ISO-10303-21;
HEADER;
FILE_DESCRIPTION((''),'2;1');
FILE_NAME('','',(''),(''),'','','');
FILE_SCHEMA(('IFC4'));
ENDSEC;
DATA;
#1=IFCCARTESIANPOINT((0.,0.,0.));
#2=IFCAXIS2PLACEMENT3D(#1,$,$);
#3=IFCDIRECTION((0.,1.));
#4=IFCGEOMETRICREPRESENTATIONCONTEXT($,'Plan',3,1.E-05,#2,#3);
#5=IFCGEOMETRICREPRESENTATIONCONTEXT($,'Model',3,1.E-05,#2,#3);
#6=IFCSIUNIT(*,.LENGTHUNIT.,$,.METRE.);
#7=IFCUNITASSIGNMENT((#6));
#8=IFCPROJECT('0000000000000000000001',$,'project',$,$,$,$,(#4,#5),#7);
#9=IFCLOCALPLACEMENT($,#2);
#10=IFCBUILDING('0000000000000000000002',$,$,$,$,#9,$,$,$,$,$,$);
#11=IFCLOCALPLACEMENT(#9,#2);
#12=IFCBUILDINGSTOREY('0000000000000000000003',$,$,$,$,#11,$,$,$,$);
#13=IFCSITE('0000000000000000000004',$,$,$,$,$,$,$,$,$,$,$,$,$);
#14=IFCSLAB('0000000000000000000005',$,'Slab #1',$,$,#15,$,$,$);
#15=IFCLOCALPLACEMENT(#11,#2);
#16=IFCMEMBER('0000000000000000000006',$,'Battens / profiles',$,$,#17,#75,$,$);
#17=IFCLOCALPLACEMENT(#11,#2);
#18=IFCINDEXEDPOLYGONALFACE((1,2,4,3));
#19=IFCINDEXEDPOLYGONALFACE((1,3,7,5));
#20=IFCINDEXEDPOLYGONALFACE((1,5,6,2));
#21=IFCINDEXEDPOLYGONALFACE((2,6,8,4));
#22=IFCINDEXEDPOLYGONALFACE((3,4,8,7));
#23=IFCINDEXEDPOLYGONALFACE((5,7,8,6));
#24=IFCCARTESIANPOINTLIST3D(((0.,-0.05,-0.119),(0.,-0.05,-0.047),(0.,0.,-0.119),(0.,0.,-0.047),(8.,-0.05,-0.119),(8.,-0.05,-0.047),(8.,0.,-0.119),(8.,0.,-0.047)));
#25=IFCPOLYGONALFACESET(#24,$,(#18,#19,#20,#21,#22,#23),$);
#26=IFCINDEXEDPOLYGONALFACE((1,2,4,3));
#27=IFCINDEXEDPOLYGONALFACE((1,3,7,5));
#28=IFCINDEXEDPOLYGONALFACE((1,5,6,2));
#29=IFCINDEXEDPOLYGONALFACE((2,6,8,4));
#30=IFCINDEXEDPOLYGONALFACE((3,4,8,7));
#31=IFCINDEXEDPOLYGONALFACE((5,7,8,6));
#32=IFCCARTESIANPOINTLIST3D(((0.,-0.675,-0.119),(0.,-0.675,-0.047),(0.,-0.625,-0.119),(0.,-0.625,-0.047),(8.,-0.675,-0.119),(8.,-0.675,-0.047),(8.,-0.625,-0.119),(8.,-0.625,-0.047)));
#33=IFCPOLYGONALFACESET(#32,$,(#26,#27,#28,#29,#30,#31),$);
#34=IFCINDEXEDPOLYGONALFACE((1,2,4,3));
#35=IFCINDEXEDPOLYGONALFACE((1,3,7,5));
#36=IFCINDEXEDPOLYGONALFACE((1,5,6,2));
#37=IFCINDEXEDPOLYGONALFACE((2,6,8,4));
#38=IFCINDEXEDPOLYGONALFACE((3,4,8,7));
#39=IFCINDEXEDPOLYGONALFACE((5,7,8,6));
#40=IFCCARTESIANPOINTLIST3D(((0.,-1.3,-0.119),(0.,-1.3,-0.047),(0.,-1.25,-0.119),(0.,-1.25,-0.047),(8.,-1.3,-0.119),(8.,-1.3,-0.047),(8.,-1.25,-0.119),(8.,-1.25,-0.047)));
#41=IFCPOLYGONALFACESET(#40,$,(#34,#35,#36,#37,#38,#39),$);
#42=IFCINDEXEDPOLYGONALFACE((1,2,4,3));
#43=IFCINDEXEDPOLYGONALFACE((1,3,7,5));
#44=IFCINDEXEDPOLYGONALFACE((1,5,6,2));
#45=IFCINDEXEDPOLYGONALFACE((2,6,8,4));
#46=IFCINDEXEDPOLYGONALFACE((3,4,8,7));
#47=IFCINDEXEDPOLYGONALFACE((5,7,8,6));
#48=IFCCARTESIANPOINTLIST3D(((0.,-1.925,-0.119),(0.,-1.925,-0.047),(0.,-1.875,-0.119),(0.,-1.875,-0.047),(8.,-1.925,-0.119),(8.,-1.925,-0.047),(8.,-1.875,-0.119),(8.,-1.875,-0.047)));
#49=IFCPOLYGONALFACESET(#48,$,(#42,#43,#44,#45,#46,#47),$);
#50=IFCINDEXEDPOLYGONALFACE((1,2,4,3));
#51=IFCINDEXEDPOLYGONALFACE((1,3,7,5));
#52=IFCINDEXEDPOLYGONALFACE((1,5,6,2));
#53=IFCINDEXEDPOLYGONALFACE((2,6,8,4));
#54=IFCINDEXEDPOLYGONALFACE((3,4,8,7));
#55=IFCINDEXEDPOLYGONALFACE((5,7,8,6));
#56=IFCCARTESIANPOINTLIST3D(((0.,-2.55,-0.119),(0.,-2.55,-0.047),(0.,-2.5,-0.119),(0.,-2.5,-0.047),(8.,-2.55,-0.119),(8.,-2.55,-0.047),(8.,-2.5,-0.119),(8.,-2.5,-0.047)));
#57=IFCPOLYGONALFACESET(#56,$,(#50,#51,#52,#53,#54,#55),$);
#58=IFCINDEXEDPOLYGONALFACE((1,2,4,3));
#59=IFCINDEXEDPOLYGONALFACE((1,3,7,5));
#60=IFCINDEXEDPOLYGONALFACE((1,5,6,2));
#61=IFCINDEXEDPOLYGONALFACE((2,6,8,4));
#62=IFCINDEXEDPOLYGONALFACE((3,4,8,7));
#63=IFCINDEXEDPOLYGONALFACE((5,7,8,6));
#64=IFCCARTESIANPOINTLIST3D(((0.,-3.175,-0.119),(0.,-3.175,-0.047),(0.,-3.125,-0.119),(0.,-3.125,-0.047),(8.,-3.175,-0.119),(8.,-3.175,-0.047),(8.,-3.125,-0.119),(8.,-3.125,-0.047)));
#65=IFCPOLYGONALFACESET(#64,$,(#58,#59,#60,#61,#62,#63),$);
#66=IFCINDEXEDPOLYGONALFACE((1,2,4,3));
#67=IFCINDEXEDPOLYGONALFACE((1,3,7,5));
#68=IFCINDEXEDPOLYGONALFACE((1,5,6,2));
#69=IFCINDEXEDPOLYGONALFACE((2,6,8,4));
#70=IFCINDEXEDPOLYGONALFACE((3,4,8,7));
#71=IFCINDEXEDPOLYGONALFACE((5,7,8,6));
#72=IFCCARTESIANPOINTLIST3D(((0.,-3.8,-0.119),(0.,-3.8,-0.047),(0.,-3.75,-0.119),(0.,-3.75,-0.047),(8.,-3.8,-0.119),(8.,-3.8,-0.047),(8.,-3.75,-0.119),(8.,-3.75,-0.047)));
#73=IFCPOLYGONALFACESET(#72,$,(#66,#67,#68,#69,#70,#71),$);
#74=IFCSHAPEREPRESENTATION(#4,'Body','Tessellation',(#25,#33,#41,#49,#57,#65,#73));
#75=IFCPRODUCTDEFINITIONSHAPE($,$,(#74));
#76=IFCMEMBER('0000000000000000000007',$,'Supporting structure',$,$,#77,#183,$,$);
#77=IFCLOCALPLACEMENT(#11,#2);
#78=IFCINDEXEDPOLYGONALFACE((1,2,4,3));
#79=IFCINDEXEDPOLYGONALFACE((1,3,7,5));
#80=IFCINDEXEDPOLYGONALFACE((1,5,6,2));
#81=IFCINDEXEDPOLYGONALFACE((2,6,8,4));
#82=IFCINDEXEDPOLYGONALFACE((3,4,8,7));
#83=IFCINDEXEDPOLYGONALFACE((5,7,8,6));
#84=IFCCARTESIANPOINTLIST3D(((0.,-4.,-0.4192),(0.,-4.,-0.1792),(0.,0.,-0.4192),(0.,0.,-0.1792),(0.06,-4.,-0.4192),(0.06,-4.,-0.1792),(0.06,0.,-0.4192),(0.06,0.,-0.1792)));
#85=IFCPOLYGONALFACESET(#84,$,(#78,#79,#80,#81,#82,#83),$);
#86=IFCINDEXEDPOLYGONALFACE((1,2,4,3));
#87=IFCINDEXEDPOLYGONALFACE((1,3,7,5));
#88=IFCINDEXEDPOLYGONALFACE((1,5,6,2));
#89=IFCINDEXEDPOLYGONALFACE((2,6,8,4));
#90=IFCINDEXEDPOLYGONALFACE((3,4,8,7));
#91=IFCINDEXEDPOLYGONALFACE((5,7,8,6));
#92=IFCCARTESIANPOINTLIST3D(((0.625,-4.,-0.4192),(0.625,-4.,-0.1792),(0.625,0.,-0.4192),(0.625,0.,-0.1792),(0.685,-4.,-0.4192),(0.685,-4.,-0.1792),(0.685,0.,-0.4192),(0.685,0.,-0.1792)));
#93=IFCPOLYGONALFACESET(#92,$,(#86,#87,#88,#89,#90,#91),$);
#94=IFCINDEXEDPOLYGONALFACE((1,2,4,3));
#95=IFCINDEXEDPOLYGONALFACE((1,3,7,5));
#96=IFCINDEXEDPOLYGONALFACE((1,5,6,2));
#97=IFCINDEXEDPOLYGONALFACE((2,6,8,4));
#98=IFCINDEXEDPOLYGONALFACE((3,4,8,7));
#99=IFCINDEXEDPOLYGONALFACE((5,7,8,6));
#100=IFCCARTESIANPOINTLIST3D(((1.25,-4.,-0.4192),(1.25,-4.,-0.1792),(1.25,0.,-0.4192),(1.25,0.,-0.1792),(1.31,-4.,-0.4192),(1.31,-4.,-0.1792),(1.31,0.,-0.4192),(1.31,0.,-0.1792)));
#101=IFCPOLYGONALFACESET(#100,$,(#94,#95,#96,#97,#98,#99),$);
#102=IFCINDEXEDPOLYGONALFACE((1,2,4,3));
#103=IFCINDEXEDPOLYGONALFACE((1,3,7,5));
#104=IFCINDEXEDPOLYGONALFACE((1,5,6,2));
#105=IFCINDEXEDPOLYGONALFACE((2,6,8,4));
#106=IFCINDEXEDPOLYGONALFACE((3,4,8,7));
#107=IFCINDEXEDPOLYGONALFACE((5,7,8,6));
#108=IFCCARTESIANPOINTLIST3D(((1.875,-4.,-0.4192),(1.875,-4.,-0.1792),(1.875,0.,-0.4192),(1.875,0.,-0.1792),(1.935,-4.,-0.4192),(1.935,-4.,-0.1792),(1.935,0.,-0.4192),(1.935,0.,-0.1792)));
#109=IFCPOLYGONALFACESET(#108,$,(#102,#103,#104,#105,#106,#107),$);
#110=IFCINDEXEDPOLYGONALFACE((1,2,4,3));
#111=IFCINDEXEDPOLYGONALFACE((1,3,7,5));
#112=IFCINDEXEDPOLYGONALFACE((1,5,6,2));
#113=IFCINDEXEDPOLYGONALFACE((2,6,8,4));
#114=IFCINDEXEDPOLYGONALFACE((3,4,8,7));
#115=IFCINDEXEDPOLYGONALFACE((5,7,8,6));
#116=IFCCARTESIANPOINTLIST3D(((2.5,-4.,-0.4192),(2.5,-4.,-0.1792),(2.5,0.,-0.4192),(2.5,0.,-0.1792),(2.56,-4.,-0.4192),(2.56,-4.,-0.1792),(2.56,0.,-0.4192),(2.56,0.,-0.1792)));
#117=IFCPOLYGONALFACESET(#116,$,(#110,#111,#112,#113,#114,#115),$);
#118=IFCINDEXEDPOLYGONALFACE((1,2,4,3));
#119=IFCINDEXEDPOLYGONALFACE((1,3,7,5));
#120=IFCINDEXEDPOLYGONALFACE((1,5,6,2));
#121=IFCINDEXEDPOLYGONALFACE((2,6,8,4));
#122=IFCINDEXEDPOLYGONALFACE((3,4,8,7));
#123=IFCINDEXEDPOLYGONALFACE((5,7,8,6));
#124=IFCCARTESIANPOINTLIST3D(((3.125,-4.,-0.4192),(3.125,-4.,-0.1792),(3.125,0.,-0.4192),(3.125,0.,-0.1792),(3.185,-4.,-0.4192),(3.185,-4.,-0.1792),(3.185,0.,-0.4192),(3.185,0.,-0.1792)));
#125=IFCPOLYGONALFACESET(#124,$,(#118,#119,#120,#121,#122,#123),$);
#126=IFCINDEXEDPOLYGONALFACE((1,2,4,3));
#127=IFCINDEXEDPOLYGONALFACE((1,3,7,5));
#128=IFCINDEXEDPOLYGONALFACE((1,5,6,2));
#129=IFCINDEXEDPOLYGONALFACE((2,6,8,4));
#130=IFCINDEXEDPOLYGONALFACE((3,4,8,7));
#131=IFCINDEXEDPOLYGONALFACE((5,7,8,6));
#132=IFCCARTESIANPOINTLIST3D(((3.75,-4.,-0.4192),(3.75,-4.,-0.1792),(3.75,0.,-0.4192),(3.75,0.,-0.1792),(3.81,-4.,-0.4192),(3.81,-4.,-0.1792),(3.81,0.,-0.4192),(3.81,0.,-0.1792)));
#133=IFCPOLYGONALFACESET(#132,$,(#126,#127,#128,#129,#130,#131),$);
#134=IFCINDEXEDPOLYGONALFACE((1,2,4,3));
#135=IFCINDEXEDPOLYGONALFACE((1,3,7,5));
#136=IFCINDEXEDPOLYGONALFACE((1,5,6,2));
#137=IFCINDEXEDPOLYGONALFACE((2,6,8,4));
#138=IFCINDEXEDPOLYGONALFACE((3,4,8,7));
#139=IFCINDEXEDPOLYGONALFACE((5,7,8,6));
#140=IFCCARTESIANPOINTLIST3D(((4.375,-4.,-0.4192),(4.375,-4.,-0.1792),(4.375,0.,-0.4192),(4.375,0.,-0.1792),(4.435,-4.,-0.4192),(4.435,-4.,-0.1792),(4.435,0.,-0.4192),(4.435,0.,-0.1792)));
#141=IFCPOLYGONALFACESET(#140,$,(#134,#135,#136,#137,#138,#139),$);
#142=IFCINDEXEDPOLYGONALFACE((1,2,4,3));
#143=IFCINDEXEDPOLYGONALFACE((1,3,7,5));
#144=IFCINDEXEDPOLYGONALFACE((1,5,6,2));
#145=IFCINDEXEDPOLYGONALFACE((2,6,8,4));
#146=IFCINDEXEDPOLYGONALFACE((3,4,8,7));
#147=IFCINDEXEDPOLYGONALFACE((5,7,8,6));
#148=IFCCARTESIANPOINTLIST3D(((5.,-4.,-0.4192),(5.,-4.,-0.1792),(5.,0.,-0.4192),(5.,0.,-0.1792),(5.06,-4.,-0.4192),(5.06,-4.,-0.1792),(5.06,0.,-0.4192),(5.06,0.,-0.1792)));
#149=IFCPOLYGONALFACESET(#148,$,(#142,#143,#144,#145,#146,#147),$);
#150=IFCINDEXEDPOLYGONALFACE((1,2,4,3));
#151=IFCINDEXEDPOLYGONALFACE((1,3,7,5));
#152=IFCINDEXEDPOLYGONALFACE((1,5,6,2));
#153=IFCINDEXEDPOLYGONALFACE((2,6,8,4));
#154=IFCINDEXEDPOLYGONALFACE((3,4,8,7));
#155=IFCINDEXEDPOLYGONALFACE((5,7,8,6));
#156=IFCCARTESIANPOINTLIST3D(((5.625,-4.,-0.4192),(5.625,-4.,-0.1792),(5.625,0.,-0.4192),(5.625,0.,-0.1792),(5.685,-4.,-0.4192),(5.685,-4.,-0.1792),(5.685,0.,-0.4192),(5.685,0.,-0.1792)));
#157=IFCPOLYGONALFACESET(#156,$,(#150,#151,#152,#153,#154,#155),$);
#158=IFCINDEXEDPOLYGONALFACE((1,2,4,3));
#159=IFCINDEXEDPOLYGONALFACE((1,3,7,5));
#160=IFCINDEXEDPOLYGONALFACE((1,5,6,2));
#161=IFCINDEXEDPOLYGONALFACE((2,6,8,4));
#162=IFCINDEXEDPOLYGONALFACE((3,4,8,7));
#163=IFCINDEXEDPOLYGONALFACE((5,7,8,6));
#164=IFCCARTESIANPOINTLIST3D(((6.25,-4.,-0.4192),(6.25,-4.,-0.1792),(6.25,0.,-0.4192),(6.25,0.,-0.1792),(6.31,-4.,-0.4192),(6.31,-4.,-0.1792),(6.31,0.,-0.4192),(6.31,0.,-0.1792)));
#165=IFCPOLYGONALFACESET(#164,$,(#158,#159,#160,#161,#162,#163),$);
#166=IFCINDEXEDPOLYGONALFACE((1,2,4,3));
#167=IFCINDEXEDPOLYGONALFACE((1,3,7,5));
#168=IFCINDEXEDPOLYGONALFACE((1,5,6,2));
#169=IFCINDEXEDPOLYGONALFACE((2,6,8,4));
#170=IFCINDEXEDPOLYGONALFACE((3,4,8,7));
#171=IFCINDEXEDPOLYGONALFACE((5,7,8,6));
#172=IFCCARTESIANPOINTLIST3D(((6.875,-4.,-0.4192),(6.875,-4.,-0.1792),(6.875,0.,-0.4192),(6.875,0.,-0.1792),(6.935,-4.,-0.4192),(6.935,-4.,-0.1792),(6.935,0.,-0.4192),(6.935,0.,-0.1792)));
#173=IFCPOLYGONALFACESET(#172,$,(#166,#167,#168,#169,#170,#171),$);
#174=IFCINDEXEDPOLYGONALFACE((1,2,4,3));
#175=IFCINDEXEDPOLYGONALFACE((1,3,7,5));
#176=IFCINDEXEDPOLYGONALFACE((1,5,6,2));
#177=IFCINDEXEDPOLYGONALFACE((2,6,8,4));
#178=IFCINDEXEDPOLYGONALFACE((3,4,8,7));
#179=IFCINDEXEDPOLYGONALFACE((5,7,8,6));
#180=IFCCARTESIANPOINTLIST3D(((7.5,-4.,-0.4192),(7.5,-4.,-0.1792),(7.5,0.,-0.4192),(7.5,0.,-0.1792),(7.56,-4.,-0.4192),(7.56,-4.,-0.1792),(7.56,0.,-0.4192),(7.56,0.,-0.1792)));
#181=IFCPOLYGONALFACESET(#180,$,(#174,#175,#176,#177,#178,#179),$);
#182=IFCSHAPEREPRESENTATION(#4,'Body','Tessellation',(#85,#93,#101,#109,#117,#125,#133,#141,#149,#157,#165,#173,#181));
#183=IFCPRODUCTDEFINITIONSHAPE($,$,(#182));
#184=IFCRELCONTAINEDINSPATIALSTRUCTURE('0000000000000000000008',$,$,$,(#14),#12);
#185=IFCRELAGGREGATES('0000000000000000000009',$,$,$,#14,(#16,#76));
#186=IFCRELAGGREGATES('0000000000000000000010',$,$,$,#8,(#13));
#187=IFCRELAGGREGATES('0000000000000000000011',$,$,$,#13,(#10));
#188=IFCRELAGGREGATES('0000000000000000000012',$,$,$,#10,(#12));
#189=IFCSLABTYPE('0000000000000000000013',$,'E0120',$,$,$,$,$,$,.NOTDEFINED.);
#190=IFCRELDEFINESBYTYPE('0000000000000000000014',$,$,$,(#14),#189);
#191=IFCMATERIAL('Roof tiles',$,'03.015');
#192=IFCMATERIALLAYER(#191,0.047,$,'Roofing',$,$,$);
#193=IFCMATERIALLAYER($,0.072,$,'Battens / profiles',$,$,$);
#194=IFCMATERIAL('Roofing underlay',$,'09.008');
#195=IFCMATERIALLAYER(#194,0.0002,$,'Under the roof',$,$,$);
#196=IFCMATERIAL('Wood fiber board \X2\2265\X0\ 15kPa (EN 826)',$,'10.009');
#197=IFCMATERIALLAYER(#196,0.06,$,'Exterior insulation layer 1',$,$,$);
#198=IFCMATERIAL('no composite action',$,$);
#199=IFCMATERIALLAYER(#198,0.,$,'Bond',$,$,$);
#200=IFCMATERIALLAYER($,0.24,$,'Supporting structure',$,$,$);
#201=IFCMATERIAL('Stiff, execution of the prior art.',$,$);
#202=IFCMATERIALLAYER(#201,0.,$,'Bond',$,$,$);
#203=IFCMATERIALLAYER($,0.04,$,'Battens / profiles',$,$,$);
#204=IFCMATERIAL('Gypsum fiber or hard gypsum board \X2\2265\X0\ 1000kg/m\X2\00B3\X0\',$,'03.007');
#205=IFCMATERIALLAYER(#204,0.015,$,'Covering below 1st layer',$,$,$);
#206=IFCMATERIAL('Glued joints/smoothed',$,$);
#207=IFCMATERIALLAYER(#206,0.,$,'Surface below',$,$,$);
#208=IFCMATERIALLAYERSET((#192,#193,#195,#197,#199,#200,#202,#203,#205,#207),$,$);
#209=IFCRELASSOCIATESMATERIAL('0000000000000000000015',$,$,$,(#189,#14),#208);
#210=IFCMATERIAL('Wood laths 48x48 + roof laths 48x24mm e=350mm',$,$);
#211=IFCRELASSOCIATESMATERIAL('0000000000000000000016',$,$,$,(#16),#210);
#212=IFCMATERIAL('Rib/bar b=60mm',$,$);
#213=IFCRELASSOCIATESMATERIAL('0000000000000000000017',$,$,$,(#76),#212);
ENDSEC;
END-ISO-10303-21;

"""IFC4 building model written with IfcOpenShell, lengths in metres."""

from ifc_helpers import new_model, si_unit, direction, frame, frame_2d, origin, place, context, project, spatial, rectangle, extrude, material, layer, layer_set, type_object, element, aggregate, save


model = new_model("IFC4")

# Units and contexts
plan_context = context("Plan", 3, precision=1e-05, world=origin(), true_north=direction((0.0, 1.0)))
model_context = context("Model", 3, precision=1e-05, world=origin(), true_north=direction((0.0, 1.0)))
ifc_project = project(units=[si_unit("LENGTHUNIT", "METRE")], contexts=[plan_context, model_context])

# Site, building, storey
site = spatial("IfcSite", under=ifc_project)
building_placement = place(None, origin())
building = spatial("IfcBuilding", under=site, at=building_placement)
storey_placement = place(building_placement, origin())
storey = spatial("IfcBuildingStorey", under=building, at=storey_placement)

# Slab, members
ifc_material_1 = material(Name="Roof tiles", Category="03.015")
ifc_layer_1 = layer(ifc_material_1, 0.047, Name="Roofing")
ifc_layer_2 = layer(None, 0.072, Name="Battens / profiles")
ifc_material_2 = material(Name="Roofing underlay", Category="09.008")
ifc_layer_3 = layer(ifc_material_2, 0.0002, Name="Under the roof")
ifc_material_3 = material(Name="Wood fiber board ≥ 15kPa (EN 826)", Category="10.009")
ifc_layer_4 = layer(ifc_material_3, 0.06, Name="Exterior insulation layer 1")
ifc_material_4 = material(Name="no composite action")
ifc_layer_5 = layer(ifc_material_4, 0.0, Name="Bond")
ifc_layer_6 = layer(None, 0.24, Name="Supporting structure")
ifc_material_5 = material(Name="Stiff, execution of the prior art.")
ifc_layer_7 = layer(ifc_material_5, 0.0, Name="Bond")
ifc_layer_8 = layer(None, 0.04, Name="Battens / profiles")
ifc_material_6 = material(Name="Gypsum fiber or hard gypsum board ≥ 1000kg/m³", Category="03.007")
ifc_layer_9 = layer(ifc_material_6, 0.015, Name="Covering below 1st layer")
ifc_material_7 = material(Name="Glued joints/smoothed")
ifc_layer_10 = layer(ifc_material_7, 0.0, Name="Surface below")
ifc_layer_set = layer_set([ifc_layer_1, ifc_layer_2, ifc_layer_3, ifc_layer_4, ifc_layer_5, ifc_layer_6, ifc_layer_7, ifc_layer_8, ifc_layer_9, ifc_layer_10])
slab_type = type_object("IfcSlabType", Name="E0120", PredefinedType="NOTDEFINED", material=ifc_layer_set)
slab_placement = place(None, frame((0.0, 0.0, 0.0), z_axis=(0.0, 0.0, -1.0), x_axis=(1.0, 0.0, 0.0)))
slab = element("IfcSlab", 1, at=slab_placement, inside=storey, type_object=slab_type, material=ifc_layer_set, Name="Slab #1")
ifc_material_8 = material(Name="Wood laths 48x48 + roof laths 48x24mm e=350mm")
member_1_placement = place(slab_placement, origin())
member_1 = element("IfcMember", 2, at=member_1_placement, material=ifc_material_8, Name="Battens / profiles", context=plan_context, shape_type="SweptSolid", body=[
    extrude(rectangle(XDim=0.05, YDim=0.072, at=frame_2d((0.025, 0.036), x_axis=(1.0, 0.0))), frame((0.0, 0.0, 0.047), z_axis=(1.0, 0.0, 0.0), x_axis=(0.0, 1.0, 0.0)), (0.0, 0.0, 1.0), 8.0),
    extrude(rectangle(XDim=0.05, YDim=0.072, at=frame_2d((0.025, 0.036), x_axis=(1.0, 0.0))), frame((0.0, 0.625, 0.047), z_axis=(1.0, 0.0, 0.0), x_axis=(0.0, 1.0, 0.0)), (0.0, 0.0, 1.0), 8.0),
    extrude(rectangle(XDim=0.05, YDim=0.072, at=frame_2d((0.025, 0.036), x_axis=(1.0, 0.0))), frame((0.0, 1.25, 0.047), z_axis=(1.0, 0.0, 0.0), x_axis=(0.0, 1.0, 0.0)), (0.0, 0.0, 1.0), 8.0),
    extrude(rectangle(XDim=0.05, YDim=0.072, at=frame_2d((0.025, 0.036), x_axis=(1.0, 0.0))), frame((0.0, 1.875, 0.047), z_axis=(1.0, 0.0, 0.0), x_axis=(0.0, 1.0, 0.0)), (0.0, 0.0, 1.0), 8.0),
    extrude(rectangle(XDim=0.05, YDim=0.072, at=frame_2d((0.025, 0.036), x_axis=(1.0, 0.0))), frame((0.0, 2.5, 0.047), z_axis=(1.0, 0.0, 0.0), x_axis=(0.0, 1.0, 0.0)), (0.0, 0.0, 1.0), 8.0),
    extrude(rectangle(XDim=0.05, YDim=0.072, at=frame_2d((0.025, 0.036), x_axis=(1.0, 0.0))), frame((0.0, 3.125, 0.047), z_axis=(1.0, 0.0, 0.0), x_axis=(0.0, 1.0, 0.0)), (0.0, 0.0, 1.0), 8.0),
    extrude(rectangle(XDim=0.05, YDim=0.072, at=frame_2d((0.025, 0.036), x_axis=(1.0, 0.0))), frame((0.0, 3.75, 0.047), z_axis=(1.0, 0.0, 0.0), x_axis=(0.0, 1.0, 0.0)), (0.0, 0.0, 1.0), 8.0),
])
ifc_material_9 = material(Name="Rib/bar b=60mm")
member_2_placement = place(slab_placement, origin())
member_2 = element("IfcMember", 3, at=member_2_placement, material=ifc_material_9, Name="Supporting structure", context=plan_context, shape_type="SweptSolid", body=[
    extrude(rectangle(XDim=0.06, YDim=0.24, at=frame_2d((0.03, 0.12), x_axis=(1.0, 0.0))), frame((0.0, 4.0, 0.1792), z_axis=(0.0, -1.0, 0.0), x_axis=(1.0, 0.0, 0.0)), (0.0, 0.0, 1.0), 4.0),
    extrude(rectangle(XDim=0.06, YDim=0.24, at=frame_2d((0.03, 0.12), x_axis=(1.0, 0.0))), frame((0.625, 4.0, 0.1792), z_axis=(0.0, -1.0, 0.0), x_axis=(1.0, 0.0, 0.0)), (0.0, 0.0, 1.0), 4.0),
    extrude(rectangle(XDim=0.06, YDim=0.24, at=frame_2d((0.03, 0.12), x_axis=(1.0, 0.0))), frame((1.25, 4.0, 0.1792), z_axis=(0.0, -1.0, 0.0), x_axis=(1.0, 0.0, 0.0)), (0.0, 0.0, 1.0), 4.0),
    extrude(rectangle(XDim=0.06, YDim=0.24, at=frame_2d((0.03, 0.12), x_axis=(1.0, 0.0))), frame((1.875, 4.0, 0.1792), z_axis=(0.0, -1.0, 0.0), x_axis=(1.0, 0.0, 0.0)), (0.0, 0.0, 1.0), 4.0),
    extrude(rectangle(XDim=0.06, YDim=0.24, at=frame_2d((0.03, 0.12), x_axis=(1.0, 0.0))), frame((2.5, 4.0, 0.1792), z_axis=(0.0, -1.0, 0.0), x_axis=(1.0, 0.0, 0.0)), (0.0, 0.0, 1.0), 4.0),
    extrude(rectangle(XDim=0.06, YDim=0.24, at=frame_2d((0.03, 0.12), x_axis=(1.0, 0.0))), frame((3.125, 4.0, 0.1792), z_axis=(0.0, -1.0, 0.0), x_axis=(1.0, 0.0, 0.0)), (0.0, 0.0, 1.0), 4.0),
    extrude(rectangle(XDim=0.06, YDim=0.24, at=frame_2d((0.03, 0.12), x_axis=(1.0, 0.0))), frame((3.75, 4.0, 0.1792), z_axis=(0.0, -1.0, 0.0), x_axis=(1.0, 0.0, 0.0)), (0.0, 0.0, 1.0), 4.0),
    extrude(rectangle(XDim=0.06, YDim=0.24, at=frame_2d((0.03, 0.12), x_axis=(1.0, 0.0))), frame((4.375, 4.0, 0.1792), z_axis=(0.0, -1.0, 0.0), x_axis=(1.0, 0.0, 0.0)), (0.0, 0.0, 1.0), 4.0),
    extrude(rectangle(XDim=0.06, YDim=0.24, at=frame_2d((0.03, 0.12), x_axis=(1.0, 0.0))), frame((5.0, 4.0, 0.1792), z_axis=(0.0, -1.0, 0.0), x_axis=(1.0, 0.0, 0.0)), (0.0, 0.0, 1.0), 4.0),
    extrude(rectangle(XDim=0.06, YDim=0.24, at=frame_2d((0.03, 0.12), x_axis=(1.0, 0.0))), frame((5.625, 4.0, 0.1792), z_axis=(0.0, -1.0, 0.0), x_axis=(1.0, 0.0, 0.0)), (0.0, 0.0, 1.0), 4.0),
    extrude(rectangle(XDim=0.06, YDim=0.24, at=frame_2d((0.03, 0.12), x_axis=(1.0, 0.0))), frame((6.25, 4.0, 0.1792), z_axis=(0.0, -1.0, 0.0), x_axis=(1.0, 0.0, 0.0)), (0.0, 0.0, 1.0), 4.0),
    extrude(rectangle(XDim=0.06, YDim=0.24, at=frame_2d((0.03, 0.12), x_axis=(1.0, 0.0))), frame((6.875, 4.0, 0.1792), z_axis=(0.0, -1.0, 0.0), x_axis=(1.0, 0.0, 0.0)), (0.0, 0.0, 1.0), 4.0),
    extrude(rectangle(XDim=0.06, YDim=0.24, at=frame_2d((0.03, 0.12), x_axis=(1.0, 0.0))), frame((7.5, 4.0, 0.1792), z_axis=(0.0, -1.0, 0.0), x_axis=(1.0, 0.0, 0.0)), (0.0, 0.0, 1.0), 4.0),
])
aggregate(slab, [member_1, member_2])

save(model, "model.ifc")
